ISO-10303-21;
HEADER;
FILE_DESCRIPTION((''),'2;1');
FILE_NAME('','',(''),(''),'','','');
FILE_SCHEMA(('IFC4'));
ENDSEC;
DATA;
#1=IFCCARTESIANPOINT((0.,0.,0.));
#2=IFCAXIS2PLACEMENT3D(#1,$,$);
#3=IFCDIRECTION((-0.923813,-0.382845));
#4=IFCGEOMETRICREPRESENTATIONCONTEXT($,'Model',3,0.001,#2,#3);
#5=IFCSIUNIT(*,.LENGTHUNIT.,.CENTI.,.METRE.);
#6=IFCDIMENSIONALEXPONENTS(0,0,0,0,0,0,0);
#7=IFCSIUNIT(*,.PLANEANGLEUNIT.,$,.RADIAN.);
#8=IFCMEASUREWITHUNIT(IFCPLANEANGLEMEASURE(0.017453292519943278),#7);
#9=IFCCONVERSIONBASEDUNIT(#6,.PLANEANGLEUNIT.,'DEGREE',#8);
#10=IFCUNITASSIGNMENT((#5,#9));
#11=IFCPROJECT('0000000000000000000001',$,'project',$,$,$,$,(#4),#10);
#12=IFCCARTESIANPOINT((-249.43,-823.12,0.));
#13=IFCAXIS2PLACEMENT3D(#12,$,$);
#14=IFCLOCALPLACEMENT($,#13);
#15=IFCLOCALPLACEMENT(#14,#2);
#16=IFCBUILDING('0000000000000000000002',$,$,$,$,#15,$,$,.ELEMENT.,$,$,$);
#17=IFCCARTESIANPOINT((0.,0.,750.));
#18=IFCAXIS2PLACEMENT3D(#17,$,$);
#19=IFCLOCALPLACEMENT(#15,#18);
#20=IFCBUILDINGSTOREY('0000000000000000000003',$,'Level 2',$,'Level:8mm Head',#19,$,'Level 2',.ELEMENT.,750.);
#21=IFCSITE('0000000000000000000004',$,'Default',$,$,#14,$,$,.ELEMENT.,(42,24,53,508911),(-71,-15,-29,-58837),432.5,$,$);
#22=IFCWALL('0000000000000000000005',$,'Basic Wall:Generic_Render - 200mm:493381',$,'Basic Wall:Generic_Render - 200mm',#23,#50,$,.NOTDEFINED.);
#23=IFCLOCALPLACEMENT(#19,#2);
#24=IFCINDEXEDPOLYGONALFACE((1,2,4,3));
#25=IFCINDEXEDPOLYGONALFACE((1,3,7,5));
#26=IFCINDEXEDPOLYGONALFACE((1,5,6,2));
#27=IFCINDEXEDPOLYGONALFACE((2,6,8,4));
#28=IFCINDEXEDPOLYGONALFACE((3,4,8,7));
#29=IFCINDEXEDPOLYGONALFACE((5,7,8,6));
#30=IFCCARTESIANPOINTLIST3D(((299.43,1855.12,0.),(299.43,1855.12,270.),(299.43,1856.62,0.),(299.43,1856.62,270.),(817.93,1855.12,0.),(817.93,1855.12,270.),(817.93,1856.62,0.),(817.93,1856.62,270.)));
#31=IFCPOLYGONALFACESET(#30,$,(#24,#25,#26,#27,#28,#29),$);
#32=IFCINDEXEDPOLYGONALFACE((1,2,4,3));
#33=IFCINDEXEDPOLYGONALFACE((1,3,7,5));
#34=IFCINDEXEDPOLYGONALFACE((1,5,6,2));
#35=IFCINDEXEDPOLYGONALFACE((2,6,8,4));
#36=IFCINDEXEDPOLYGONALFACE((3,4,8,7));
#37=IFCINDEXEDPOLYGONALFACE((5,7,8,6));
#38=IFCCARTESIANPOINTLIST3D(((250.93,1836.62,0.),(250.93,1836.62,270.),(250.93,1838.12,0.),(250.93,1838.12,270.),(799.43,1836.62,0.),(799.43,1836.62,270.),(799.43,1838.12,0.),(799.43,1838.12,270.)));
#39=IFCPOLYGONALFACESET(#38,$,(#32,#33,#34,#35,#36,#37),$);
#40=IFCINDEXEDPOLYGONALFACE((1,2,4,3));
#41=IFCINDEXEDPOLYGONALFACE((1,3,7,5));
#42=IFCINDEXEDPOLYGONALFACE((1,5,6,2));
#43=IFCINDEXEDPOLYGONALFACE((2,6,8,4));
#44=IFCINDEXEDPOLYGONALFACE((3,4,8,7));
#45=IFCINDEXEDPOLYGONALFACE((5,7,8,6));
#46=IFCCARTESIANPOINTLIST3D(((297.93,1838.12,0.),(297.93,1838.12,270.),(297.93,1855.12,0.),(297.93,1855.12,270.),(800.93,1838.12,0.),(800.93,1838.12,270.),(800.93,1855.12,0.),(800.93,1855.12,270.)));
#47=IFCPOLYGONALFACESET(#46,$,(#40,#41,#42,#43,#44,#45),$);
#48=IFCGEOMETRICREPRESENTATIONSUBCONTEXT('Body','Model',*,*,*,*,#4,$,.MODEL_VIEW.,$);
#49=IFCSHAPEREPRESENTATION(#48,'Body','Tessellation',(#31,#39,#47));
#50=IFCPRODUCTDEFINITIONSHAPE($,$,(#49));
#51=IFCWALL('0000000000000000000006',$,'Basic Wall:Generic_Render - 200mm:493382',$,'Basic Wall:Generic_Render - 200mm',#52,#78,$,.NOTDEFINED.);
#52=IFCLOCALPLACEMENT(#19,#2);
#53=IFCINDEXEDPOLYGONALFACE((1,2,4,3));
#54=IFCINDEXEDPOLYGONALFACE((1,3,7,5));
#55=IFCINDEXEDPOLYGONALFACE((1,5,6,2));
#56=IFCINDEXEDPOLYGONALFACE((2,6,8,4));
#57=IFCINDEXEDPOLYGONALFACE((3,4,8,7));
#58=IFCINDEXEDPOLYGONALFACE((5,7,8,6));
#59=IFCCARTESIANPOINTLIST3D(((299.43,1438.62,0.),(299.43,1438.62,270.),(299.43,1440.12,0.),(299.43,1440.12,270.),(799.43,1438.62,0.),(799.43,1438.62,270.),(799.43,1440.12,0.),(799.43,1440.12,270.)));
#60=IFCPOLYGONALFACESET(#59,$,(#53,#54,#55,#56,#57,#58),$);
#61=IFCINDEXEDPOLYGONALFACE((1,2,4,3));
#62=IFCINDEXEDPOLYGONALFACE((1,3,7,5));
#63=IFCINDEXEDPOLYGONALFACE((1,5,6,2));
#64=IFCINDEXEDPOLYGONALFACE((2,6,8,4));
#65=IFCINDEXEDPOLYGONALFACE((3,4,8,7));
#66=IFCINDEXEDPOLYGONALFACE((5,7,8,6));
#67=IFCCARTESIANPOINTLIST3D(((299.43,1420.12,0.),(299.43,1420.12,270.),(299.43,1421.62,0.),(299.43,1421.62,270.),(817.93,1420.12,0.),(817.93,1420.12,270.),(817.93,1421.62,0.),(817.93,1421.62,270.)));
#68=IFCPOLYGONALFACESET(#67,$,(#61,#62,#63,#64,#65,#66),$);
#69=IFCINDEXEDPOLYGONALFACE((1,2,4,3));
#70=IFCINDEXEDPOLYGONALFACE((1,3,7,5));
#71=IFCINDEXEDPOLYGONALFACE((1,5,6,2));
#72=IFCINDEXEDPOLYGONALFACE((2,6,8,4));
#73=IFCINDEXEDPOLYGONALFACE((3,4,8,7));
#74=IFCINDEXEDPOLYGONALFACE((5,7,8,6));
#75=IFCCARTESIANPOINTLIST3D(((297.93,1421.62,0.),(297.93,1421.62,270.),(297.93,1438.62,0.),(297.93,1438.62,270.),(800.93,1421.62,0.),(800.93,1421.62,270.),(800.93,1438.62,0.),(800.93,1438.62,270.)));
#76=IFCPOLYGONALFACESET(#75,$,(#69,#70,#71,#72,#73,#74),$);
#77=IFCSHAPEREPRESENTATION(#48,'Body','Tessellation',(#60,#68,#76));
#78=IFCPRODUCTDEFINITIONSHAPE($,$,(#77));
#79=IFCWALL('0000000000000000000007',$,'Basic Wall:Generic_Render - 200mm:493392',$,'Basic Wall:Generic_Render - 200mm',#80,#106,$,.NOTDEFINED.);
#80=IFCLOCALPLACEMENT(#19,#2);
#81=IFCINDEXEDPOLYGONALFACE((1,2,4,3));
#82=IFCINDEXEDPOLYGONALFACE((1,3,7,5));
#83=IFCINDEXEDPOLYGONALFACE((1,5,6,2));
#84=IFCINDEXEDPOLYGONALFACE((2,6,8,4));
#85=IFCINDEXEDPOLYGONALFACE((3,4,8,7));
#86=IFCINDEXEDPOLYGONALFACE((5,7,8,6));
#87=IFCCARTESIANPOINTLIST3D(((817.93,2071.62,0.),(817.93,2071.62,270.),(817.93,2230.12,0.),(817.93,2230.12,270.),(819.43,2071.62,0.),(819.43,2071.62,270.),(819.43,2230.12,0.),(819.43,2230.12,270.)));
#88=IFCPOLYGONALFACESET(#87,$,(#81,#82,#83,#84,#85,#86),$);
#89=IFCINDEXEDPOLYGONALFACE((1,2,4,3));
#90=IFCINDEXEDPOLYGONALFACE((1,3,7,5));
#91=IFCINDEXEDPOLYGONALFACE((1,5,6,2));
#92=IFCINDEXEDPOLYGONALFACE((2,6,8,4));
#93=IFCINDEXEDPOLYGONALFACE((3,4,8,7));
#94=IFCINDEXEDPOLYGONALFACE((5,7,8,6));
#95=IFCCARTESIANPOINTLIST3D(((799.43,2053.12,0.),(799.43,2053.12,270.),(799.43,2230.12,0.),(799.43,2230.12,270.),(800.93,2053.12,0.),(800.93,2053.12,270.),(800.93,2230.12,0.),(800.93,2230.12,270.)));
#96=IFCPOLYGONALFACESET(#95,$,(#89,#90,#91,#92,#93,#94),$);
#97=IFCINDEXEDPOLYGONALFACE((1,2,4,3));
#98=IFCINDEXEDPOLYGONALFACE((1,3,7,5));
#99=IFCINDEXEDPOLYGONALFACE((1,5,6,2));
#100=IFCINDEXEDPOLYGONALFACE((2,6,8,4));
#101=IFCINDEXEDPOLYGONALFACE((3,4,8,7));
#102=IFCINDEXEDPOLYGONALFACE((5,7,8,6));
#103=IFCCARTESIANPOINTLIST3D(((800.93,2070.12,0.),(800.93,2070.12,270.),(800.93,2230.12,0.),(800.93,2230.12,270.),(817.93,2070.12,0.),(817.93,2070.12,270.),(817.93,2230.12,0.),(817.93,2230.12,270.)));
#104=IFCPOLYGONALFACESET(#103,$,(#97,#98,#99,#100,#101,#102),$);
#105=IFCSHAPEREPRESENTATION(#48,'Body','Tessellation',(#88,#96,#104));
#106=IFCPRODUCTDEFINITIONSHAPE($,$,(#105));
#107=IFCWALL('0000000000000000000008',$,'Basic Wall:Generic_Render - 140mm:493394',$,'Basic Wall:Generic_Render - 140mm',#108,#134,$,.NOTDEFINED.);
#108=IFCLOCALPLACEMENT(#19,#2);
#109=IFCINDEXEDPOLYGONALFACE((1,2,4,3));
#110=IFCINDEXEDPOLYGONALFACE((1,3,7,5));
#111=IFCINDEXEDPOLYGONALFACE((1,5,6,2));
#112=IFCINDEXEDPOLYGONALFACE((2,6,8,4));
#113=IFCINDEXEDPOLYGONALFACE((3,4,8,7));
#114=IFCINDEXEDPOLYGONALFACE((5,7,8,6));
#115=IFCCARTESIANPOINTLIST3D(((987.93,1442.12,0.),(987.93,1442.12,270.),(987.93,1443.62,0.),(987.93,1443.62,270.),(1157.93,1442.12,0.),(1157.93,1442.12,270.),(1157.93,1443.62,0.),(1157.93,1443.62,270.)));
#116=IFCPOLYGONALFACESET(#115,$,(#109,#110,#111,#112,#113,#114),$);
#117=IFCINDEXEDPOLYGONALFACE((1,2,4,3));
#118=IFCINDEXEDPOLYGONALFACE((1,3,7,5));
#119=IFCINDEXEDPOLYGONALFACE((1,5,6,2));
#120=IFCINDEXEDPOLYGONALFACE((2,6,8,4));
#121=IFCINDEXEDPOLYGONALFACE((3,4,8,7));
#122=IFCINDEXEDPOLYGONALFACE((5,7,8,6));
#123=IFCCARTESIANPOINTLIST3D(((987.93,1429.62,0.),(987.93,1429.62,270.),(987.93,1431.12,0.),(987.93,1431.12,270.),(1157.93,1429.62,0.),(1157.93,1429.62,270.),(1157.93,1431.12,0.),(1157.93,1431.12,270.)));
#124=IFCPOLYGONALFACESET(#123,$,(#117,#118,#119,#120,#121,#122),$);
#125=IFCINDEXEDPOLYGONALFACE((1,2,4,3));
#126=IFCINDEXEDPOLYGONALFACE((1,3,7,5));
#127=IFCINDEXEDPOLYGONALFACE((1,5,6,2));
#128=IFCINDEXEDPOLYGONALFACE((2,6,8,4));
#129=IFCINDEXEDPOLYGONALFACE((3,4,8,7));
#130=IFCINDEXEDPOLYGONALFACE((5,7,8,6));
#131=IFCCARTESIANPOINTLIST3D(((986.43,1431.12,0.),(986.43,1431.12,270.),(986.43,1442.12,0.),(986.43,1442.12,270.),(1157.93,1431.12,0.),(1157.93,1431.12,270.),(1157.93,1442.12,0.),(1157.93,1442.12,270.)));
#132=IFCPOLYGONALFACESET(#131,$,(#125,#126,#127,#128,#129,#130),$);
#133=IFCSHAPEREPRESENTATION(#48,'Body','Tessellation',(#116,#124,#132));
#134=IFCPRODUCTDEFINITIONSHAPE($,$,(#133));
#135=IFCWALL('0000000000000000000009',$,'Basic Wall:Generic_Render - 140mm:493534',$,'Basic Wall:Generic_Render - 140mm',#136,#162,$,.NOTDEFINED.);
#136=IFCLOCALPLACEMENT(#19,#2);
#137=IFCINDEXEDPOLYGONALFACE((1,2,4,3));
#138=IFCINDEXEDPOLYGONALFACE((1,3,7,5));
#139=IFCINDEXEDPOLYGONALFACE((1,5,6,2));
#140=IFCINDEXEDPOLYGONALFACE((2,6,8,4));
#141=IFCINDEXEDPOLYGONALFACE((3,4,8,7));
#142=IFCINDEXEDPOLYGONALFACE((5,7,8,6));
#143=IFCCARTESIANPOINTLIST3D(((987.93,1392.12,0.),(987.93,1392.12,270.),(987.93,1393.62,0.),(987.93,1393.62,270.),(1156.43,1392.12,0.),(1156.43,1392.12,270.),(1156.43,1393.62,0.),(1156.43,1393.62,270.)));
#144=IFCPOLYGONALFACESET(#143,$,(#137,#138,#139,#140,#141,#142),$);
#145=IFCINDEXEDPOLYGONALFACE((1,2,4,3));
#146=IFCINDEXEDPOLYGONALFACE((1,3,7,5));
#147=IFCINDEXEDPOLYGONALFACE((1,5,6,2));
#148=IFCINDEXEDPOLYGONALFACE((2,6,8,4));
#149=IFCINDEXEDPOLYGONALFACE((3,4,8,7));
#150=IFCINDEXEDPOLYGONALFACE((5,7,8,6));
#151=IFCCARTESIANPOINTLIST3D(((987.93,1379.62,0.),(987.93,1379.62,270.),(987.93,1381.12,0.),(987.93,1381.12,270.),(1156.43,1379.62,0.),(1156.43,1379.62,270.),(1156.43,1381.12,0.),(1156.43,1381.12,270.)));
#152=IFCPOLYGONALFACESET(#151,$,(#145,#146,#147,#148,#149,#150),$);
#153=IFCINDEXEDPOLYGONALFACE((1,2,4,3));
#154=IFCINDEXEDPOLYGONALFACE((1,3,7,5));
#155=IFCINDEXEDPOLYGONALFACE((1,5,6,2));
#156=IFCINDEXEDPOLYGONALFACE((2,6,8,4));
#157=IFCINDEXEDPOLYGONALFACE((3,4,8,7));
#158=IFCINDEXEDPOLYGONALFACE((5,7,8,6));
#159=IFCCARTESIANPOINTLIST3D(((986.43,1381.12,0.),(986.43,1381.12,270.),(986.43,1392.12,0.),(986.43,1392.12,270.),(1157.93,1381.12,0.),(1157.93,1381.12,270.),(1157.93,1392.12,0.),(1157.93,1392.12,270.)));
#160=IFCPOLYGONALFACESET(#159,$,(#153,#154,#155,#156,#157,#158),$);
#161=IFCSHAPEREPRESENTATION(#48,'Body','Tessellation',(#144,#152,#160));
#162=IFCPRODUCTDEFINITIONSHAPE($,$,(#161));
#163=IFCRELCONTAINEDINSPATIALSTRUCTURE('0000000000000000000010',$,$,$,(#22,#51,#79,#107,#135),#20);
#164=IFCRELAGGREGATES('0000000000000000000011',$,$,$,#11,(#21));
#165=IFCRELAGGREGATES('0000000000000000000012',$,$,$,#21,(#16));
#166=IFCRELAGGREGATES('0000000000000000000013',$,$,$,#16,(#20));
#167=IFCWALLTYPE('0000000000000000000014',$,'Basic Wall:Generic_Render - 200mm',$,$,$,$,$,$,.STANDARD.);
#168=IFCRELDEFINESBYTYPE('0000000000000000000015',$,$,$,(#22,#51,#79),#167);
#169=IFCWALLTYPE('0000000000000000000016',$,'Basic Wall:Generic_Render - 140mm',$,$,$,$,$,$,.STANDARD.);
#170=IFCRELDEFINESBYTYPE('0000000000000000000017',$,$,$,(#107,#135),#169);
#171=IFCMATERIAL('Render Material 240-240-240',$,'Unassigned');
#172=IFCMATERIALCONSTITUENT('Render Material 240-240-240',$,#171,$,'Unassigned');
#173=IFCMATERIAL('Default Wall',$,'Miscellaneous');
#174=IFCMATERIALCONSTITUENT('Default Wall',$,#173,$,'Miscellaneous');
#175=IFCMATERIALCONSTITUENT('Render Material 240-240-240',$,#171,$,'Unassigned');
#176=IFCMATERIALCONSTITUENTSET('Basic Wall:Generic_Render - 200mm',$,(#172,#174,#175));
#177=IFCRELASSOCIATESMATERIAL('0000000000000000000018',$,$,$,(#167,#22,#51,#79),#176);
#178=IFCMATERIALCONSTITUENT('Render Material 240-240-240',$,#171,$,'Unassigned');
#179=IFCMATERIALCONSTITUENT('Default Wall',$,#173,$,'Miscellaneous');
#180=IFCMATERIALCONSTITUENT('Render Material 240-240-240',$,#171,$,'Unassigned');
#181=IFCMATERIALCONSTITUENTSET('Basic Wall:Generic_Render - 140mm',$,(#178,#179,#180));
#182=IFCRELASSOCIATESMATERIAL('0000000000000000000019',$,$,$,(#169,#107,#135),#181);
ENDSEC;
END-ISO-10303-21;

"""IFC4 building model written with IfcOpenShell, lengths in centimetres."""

from ifc_helpers import new_model, entity, si_unit, converted_unit, direction, frame, origin, place, context, subcontext, project, spatial, indexed_curve, outline, extrude, material, constituent, constituent_set, type_object, element, save


model = new_model("IFC4")

# Units and contexts
model_context = context("Model", 3, precision=0.001, world=origin(), true_north=direction((-0.923813, -0.382845)))
body_context = subcontext(model_context, "Body", "Model", "MODEL_VIEW")
ifc_project = project(units=[si_unit("LENGTHUNIT", "METRE", prefix="CENTI"), converted_unit("PLANEANGLEUNIT", "DEGREE", entity("IfcPlaneAngleMeasure", 0.017453292519943278), si_unit("PLANEANGLEUNIT", "RADIAN"), dimensions=[0, 0, 0, 0, 0, 0, 0])], contexts=[model_context])

# Site, building, storey
site_placement = place(None, frame((-249.43, -823.12, 0.0)))
site = spatial("IfcSite", under=ifc_project, at=site_placement, Name="Default", CompositionType="ELEMENT", RefLatitude=(42, 24, 53, 508911), RefLongitude=(-71, -15, -29, -58837), RefElevation=432.5)
building_placement = place(site_placement, origin())
building = spatial("IfcBuilding", under=site, at=building_placement, CompositionType="ELEMENT")
storey_placement = place(building_placement, frame((0.0, 0.0, 750.0)))
storey = spatial("IfcBuildingStorey", under=building, at=storey_placement, Name="Level 2", ObjectType="Level:8mm Head", LongName="Level 2", CompositionType="ELEMENT", Elevation=750.0)

# Shared definitions
ifc_material_1 = material(Name="Render Material 240-240-240", Category="Unassigned")
ifc_material_2 = material(Name="Default Wall", Category="Miscellaneous")

# Shared definitions
ifc_constituent_1 = constituent(ifc_material_1, Name="Render Material 240-240-240", Category="Unassigned")
ifc_constituent_2 = constituent(ifc_material_2, Name="Default Wall", Category="Miscellaneous")
ifc_constituent_3 = constituent(ifc_material_1, Name="Render Material 240-240-240", Category="Unassigned")
ifc_constituent_set_1 = constituent_set(constituents=[ifc_constituent_1, ifc_constituent_2, ifc_constituent_3], Name="Basic Wall:Generic_Render - 200mm")
wall_type_1 = type_object("IfcWallType", Name="Basic Wall:Generic_Render - 200mm", PredefinedType="STANDARD", material=ifc_constituent_set_1)

# Walls
wall_1_placement = place(storey_placement, frame((799.43, 1846.62, 0.0), z_axis=(0.0, 0.0, 1.0), x_axis=(-1.0, 0.0, 0.0)))
element("IfcWall", 1, at=wall_1_placement, inside=storey, type_object=wall_type_1, material=ifc_constituent_set_1, Name="Basic Wall:Generic_Render - 200mm:493381", ObjectType="Basic Wall:Generic_Render - 200mm", PredefinedType="NOTDEFINED", context=body_context, shape_type="SweptSolid", body=[
    extrude(outline(indexed_curve([(-0.75, -259.25), (0.75, -259.25), (0.75, 259.25), (-0.75, 259.25), (-0.75, -259.25)], self_intersect=False)), frame((240.75, -9.25, 0.0), z_axis=(0.0, 0.0, 1.0), x_axis=(0.0, 1.0, 0.0)), (0.0, 0.0, 1.0), 270.0),
    extrude(outline(indexed_curve([(-0.75, -274.25), (0.75, -274.25), (0.75, 274.25), (-0.75, 274.25), (-0.75, -274.25)], self_intersect=False)), frame((274.25, 9.25, 0.0), z_axis=(0.0, 0.0, 1.0), x_axis=(0.0, -1.0, 0.0)), (0.0, 0.0, 1.0), 270.0),
    extrude(outline(indexed_curve([(-251.5, -8.5), (251.5, -8.5), (251.5, 8.5), (-251.5, 8.5), (-251.5, -8.5)], self_intersect=False)), frame((250.0, 0.0, 0.0)), (0.0, 0.0, 1.0), 270.0),
])
wall_2_placement = place(storey_placement, frame((799.43, 1430.12, 0.0), z_axis=(0.0, 0.0, 1.0), x_axis=(-1.0, 0.0, 0.0)))
element("IfcWall", 2, at=wall_2_placement, inside=storey, type_object=wall_type_1, material=ifc_constituent_set_1, Name="Basic Wall:Generic_Render - 200mm:493382", ObjectType="Basic Wall:Generic_Render - 200mm", PredefinedType="NOTDEFINED", context=body_context, shape_type="SweptSolid", body=[
    extrude(outline(indexed_curve([(-0.75, -250.0), (0.75, -250.0), (0.75, 250.0), (-0.75, 250.0), (-0.75, -250.0)], self_intersect=False)), frame((250.0, -9.25, 0.0), z_axis=(0.0, 0.0, 1.0), x_axis=(0.0, 1.0, 0.0)), (0.0, 0.0, 1.0), 270.0),
    extrude(outline(indexed_curve([(-0.75, -259.25), (0.75, -259.25), (0.75, 259.25), (-0.75, 259.25), (-0.75, -259.25)], self_intersect=False)), frame((240.75, 9.25, 0.0), z_axis=(0.0, 0.0, 1.0), x_axis=(0.0, -1.0, 0.0)), (0.0, 0.0, 1.0), 270.0),
    extrude(outline(indexed_curve([(-251.5, -8.5), (251.5, -8.5), (251.5, 8.5), (-251.5, 8.5), (-251.5, -8.5)], self_intersect=False)), frame((250.0, 0.0, 0.0)), (0.0, 0.0, 1.0), 270.0),
])

# Walls
wall_3_placement = place(storey_placement, frame((809.43, 2071.62, 0.0), z_axis=(0.0, 0.0, 1.0), x_axis=(0.0, 1.0, 0.0)))
element("IfcWall", 3, at=wall_3_placement, inside=storey, type_object=wall_type_1, material=ifc_constituent_set_1, Name="Basic Wall:Generic_Render - 200mm:493392", ObjectType="Basic Wall:Generic_Render - 200mm", PredefinedType="NOTDEFINED", context=body_context, shape_type="SweptSolid", body=[
    extrude(outline(indexed_curve([(-0.75, -79.25), (0.75, -79.25), (0.75, 79.25), (-0.75, 79.25), (-0.75, -79.25)], self_intersect=False)), frame((79.25, -9.25, 0.0), z_axis=(0.0, 0.0, 1.0), x_axis=(0.0, 1.0, 0.0)), (0.0, 0.0, 1.0), 270.0),
    extrude(outline(indexed_curve([(-0.75, -88.5), (0.75, -88.5), (0.75, 88.5), (-0.75, 88.5), (-0.75, -88.5)], self_intersect=False)), frame((70.0, 9.25, 0.0), z_axis=(0.0, 0.0, 1.0), x_axis=(0.0, -1.0, 0.0)), (0.0, 0.0, 1.0), 270.0),
    extrude(outline(indexed_curve([(-80.0, -8.5), (80.0, -8.5), (80.0, 8.5), (-80.0, 8.5), (-80.0, -8.5)], self_intersect=False)), frame((78.5, 0.0, 0.0)), (0.0, 0.0, 1.0), 270.0),
])
ifc_constituent_4 = constituent(ifc_material_1, Name="Render Material 240-240-240", Category="Unassigned")
ifc_constituent_5 = constituent(ifc_material_2, Name="Default Wall", Category="Miscellaneous")
ifc_constituent_6 = constituent(ifc_material_1, Name="Render Material 240-240-240", Category="Unassigned")
ifc_constituent_set_2 = constituent_set(constituents=[ifc_constituent_4, ifc_constituent_5, ifc_constituent_6], Name="Basic Wall:Generic_Render - 140mm")
wall_type_2 = type_object("IfcWallType", Name="Basic Wall:Generic_Render - 140mm", PredefinedType="STANDARD", material=ifc_constituent_set_2)
wall_4_placement = place(storey_placement, frame((1157.93, 1436.62, 0.0), z_axis=(0.0, 0.0, 1.0), x_axis=(-1.0, 0.0, 0.0)))
element("IfcWall", 4, at=wall_4_placement, inside=storey, type_object=wall_type_2, material=ifc_constituent_set_2, Name="Basic Wall:Generic_Render - 140mm:493394", ObjectType="Basic Wall:Generic_Render - 140mm", PredefinedType="NOTDEFINED", context=body_context, shape_type="SweptSolid", body=[
    extrude(outline(indexed_curve([(-0.75, -85.0), (0.75, -85.0), (0.75, 85.0), (-0.75, 85.0), (-0.75, -85.0)], self_intersect=False)), frame((85.0, -6.25, 0.0), z_axis=(0.0, 0.0, 1.0), x_axis=(0.0, 1.0, 0.0)), (0.0, 0.0, 1.0), 270.0),
    extrude(outline(indexed_curve([(-0.75, -85.0), (0.75, -85.0), (0.75, 85.0), (-0.75, 85.0), (-0.75, -85.0)], self_intersect=False)), frame((85.0, 6.25, 0.0), z_axis=(0.0, 0.0, 1.0), x_axis=(0.0, -1.0, 0.0)), (0.0, 0.0, 1.0), 270.0),
    extrude(outline(indexed_curve([(-85.75, -5.5), (85.75, -5.5), (85.75, 5.5), (-85.75, 5.5), (-85.75, -5.5)], self_intersect=False)), frame((85.75, 0.0, 0.0)), (0.0, 0.0, 1.0), 270.0),
])
wall_5_placement = place(storey_placement, frame((1156.43, 1386.62, 0.0), z_axis=(0.0, 0.0, 1.0), x_axis=(-1.0, 0.0, 0.0)))
element("IfcWall", 5, at=wall_5_placement, inside=storey, type_object=wall_type_2, material=ifc_constituent_set_2, Name="Basic Wall:Generic_Render - 140mm:493534", ObjectType="Basic Wall:Generic_Render - 140mm", PredefinedType="NOTDEFINED", context=body_context, shape_type="SweptSolid", body=[
    extrude(outline(indexed_curve([(-0.75, -84.25), (0.75, -84.25), (0.75, 84.25), (-0.75, 84.25), (-0.75, -84.25)], self_intersect=False)), frame((84.25, -6.25, 0.0), z_axis=(0.0, 0.0, 1.0), x_axis=(0.0, 1.0, 0.0)), (0.0, 0.0, 1.0), 270.0),
    extrude(outline(indexed_curve([(-0.75, -84.25), (0.75, -84.25), (0.75, 84.25), (-0.75, 84.25), (-0.75, -84.25)], self_intersect=False)), frame((84.25, 6.25, 0.0), z_axis=(0.0, 0.0, 1.0), x_axis=(0.0, -1.0, 0.0)), (0.0, 0.0, 1.0), 270.0),
    extrude(outline(indexed_curve([(-85.75, -5.5), (85.75, -5.5), (85.75, 5.5), (-85.75, 5.5), (-85.75, -5.5)], self_intersect=False)), frame((84.25, 0.0, 0.0)), (0.0, 0.0, 1.0), 270.0),
])

save(model, "model.ifc")
